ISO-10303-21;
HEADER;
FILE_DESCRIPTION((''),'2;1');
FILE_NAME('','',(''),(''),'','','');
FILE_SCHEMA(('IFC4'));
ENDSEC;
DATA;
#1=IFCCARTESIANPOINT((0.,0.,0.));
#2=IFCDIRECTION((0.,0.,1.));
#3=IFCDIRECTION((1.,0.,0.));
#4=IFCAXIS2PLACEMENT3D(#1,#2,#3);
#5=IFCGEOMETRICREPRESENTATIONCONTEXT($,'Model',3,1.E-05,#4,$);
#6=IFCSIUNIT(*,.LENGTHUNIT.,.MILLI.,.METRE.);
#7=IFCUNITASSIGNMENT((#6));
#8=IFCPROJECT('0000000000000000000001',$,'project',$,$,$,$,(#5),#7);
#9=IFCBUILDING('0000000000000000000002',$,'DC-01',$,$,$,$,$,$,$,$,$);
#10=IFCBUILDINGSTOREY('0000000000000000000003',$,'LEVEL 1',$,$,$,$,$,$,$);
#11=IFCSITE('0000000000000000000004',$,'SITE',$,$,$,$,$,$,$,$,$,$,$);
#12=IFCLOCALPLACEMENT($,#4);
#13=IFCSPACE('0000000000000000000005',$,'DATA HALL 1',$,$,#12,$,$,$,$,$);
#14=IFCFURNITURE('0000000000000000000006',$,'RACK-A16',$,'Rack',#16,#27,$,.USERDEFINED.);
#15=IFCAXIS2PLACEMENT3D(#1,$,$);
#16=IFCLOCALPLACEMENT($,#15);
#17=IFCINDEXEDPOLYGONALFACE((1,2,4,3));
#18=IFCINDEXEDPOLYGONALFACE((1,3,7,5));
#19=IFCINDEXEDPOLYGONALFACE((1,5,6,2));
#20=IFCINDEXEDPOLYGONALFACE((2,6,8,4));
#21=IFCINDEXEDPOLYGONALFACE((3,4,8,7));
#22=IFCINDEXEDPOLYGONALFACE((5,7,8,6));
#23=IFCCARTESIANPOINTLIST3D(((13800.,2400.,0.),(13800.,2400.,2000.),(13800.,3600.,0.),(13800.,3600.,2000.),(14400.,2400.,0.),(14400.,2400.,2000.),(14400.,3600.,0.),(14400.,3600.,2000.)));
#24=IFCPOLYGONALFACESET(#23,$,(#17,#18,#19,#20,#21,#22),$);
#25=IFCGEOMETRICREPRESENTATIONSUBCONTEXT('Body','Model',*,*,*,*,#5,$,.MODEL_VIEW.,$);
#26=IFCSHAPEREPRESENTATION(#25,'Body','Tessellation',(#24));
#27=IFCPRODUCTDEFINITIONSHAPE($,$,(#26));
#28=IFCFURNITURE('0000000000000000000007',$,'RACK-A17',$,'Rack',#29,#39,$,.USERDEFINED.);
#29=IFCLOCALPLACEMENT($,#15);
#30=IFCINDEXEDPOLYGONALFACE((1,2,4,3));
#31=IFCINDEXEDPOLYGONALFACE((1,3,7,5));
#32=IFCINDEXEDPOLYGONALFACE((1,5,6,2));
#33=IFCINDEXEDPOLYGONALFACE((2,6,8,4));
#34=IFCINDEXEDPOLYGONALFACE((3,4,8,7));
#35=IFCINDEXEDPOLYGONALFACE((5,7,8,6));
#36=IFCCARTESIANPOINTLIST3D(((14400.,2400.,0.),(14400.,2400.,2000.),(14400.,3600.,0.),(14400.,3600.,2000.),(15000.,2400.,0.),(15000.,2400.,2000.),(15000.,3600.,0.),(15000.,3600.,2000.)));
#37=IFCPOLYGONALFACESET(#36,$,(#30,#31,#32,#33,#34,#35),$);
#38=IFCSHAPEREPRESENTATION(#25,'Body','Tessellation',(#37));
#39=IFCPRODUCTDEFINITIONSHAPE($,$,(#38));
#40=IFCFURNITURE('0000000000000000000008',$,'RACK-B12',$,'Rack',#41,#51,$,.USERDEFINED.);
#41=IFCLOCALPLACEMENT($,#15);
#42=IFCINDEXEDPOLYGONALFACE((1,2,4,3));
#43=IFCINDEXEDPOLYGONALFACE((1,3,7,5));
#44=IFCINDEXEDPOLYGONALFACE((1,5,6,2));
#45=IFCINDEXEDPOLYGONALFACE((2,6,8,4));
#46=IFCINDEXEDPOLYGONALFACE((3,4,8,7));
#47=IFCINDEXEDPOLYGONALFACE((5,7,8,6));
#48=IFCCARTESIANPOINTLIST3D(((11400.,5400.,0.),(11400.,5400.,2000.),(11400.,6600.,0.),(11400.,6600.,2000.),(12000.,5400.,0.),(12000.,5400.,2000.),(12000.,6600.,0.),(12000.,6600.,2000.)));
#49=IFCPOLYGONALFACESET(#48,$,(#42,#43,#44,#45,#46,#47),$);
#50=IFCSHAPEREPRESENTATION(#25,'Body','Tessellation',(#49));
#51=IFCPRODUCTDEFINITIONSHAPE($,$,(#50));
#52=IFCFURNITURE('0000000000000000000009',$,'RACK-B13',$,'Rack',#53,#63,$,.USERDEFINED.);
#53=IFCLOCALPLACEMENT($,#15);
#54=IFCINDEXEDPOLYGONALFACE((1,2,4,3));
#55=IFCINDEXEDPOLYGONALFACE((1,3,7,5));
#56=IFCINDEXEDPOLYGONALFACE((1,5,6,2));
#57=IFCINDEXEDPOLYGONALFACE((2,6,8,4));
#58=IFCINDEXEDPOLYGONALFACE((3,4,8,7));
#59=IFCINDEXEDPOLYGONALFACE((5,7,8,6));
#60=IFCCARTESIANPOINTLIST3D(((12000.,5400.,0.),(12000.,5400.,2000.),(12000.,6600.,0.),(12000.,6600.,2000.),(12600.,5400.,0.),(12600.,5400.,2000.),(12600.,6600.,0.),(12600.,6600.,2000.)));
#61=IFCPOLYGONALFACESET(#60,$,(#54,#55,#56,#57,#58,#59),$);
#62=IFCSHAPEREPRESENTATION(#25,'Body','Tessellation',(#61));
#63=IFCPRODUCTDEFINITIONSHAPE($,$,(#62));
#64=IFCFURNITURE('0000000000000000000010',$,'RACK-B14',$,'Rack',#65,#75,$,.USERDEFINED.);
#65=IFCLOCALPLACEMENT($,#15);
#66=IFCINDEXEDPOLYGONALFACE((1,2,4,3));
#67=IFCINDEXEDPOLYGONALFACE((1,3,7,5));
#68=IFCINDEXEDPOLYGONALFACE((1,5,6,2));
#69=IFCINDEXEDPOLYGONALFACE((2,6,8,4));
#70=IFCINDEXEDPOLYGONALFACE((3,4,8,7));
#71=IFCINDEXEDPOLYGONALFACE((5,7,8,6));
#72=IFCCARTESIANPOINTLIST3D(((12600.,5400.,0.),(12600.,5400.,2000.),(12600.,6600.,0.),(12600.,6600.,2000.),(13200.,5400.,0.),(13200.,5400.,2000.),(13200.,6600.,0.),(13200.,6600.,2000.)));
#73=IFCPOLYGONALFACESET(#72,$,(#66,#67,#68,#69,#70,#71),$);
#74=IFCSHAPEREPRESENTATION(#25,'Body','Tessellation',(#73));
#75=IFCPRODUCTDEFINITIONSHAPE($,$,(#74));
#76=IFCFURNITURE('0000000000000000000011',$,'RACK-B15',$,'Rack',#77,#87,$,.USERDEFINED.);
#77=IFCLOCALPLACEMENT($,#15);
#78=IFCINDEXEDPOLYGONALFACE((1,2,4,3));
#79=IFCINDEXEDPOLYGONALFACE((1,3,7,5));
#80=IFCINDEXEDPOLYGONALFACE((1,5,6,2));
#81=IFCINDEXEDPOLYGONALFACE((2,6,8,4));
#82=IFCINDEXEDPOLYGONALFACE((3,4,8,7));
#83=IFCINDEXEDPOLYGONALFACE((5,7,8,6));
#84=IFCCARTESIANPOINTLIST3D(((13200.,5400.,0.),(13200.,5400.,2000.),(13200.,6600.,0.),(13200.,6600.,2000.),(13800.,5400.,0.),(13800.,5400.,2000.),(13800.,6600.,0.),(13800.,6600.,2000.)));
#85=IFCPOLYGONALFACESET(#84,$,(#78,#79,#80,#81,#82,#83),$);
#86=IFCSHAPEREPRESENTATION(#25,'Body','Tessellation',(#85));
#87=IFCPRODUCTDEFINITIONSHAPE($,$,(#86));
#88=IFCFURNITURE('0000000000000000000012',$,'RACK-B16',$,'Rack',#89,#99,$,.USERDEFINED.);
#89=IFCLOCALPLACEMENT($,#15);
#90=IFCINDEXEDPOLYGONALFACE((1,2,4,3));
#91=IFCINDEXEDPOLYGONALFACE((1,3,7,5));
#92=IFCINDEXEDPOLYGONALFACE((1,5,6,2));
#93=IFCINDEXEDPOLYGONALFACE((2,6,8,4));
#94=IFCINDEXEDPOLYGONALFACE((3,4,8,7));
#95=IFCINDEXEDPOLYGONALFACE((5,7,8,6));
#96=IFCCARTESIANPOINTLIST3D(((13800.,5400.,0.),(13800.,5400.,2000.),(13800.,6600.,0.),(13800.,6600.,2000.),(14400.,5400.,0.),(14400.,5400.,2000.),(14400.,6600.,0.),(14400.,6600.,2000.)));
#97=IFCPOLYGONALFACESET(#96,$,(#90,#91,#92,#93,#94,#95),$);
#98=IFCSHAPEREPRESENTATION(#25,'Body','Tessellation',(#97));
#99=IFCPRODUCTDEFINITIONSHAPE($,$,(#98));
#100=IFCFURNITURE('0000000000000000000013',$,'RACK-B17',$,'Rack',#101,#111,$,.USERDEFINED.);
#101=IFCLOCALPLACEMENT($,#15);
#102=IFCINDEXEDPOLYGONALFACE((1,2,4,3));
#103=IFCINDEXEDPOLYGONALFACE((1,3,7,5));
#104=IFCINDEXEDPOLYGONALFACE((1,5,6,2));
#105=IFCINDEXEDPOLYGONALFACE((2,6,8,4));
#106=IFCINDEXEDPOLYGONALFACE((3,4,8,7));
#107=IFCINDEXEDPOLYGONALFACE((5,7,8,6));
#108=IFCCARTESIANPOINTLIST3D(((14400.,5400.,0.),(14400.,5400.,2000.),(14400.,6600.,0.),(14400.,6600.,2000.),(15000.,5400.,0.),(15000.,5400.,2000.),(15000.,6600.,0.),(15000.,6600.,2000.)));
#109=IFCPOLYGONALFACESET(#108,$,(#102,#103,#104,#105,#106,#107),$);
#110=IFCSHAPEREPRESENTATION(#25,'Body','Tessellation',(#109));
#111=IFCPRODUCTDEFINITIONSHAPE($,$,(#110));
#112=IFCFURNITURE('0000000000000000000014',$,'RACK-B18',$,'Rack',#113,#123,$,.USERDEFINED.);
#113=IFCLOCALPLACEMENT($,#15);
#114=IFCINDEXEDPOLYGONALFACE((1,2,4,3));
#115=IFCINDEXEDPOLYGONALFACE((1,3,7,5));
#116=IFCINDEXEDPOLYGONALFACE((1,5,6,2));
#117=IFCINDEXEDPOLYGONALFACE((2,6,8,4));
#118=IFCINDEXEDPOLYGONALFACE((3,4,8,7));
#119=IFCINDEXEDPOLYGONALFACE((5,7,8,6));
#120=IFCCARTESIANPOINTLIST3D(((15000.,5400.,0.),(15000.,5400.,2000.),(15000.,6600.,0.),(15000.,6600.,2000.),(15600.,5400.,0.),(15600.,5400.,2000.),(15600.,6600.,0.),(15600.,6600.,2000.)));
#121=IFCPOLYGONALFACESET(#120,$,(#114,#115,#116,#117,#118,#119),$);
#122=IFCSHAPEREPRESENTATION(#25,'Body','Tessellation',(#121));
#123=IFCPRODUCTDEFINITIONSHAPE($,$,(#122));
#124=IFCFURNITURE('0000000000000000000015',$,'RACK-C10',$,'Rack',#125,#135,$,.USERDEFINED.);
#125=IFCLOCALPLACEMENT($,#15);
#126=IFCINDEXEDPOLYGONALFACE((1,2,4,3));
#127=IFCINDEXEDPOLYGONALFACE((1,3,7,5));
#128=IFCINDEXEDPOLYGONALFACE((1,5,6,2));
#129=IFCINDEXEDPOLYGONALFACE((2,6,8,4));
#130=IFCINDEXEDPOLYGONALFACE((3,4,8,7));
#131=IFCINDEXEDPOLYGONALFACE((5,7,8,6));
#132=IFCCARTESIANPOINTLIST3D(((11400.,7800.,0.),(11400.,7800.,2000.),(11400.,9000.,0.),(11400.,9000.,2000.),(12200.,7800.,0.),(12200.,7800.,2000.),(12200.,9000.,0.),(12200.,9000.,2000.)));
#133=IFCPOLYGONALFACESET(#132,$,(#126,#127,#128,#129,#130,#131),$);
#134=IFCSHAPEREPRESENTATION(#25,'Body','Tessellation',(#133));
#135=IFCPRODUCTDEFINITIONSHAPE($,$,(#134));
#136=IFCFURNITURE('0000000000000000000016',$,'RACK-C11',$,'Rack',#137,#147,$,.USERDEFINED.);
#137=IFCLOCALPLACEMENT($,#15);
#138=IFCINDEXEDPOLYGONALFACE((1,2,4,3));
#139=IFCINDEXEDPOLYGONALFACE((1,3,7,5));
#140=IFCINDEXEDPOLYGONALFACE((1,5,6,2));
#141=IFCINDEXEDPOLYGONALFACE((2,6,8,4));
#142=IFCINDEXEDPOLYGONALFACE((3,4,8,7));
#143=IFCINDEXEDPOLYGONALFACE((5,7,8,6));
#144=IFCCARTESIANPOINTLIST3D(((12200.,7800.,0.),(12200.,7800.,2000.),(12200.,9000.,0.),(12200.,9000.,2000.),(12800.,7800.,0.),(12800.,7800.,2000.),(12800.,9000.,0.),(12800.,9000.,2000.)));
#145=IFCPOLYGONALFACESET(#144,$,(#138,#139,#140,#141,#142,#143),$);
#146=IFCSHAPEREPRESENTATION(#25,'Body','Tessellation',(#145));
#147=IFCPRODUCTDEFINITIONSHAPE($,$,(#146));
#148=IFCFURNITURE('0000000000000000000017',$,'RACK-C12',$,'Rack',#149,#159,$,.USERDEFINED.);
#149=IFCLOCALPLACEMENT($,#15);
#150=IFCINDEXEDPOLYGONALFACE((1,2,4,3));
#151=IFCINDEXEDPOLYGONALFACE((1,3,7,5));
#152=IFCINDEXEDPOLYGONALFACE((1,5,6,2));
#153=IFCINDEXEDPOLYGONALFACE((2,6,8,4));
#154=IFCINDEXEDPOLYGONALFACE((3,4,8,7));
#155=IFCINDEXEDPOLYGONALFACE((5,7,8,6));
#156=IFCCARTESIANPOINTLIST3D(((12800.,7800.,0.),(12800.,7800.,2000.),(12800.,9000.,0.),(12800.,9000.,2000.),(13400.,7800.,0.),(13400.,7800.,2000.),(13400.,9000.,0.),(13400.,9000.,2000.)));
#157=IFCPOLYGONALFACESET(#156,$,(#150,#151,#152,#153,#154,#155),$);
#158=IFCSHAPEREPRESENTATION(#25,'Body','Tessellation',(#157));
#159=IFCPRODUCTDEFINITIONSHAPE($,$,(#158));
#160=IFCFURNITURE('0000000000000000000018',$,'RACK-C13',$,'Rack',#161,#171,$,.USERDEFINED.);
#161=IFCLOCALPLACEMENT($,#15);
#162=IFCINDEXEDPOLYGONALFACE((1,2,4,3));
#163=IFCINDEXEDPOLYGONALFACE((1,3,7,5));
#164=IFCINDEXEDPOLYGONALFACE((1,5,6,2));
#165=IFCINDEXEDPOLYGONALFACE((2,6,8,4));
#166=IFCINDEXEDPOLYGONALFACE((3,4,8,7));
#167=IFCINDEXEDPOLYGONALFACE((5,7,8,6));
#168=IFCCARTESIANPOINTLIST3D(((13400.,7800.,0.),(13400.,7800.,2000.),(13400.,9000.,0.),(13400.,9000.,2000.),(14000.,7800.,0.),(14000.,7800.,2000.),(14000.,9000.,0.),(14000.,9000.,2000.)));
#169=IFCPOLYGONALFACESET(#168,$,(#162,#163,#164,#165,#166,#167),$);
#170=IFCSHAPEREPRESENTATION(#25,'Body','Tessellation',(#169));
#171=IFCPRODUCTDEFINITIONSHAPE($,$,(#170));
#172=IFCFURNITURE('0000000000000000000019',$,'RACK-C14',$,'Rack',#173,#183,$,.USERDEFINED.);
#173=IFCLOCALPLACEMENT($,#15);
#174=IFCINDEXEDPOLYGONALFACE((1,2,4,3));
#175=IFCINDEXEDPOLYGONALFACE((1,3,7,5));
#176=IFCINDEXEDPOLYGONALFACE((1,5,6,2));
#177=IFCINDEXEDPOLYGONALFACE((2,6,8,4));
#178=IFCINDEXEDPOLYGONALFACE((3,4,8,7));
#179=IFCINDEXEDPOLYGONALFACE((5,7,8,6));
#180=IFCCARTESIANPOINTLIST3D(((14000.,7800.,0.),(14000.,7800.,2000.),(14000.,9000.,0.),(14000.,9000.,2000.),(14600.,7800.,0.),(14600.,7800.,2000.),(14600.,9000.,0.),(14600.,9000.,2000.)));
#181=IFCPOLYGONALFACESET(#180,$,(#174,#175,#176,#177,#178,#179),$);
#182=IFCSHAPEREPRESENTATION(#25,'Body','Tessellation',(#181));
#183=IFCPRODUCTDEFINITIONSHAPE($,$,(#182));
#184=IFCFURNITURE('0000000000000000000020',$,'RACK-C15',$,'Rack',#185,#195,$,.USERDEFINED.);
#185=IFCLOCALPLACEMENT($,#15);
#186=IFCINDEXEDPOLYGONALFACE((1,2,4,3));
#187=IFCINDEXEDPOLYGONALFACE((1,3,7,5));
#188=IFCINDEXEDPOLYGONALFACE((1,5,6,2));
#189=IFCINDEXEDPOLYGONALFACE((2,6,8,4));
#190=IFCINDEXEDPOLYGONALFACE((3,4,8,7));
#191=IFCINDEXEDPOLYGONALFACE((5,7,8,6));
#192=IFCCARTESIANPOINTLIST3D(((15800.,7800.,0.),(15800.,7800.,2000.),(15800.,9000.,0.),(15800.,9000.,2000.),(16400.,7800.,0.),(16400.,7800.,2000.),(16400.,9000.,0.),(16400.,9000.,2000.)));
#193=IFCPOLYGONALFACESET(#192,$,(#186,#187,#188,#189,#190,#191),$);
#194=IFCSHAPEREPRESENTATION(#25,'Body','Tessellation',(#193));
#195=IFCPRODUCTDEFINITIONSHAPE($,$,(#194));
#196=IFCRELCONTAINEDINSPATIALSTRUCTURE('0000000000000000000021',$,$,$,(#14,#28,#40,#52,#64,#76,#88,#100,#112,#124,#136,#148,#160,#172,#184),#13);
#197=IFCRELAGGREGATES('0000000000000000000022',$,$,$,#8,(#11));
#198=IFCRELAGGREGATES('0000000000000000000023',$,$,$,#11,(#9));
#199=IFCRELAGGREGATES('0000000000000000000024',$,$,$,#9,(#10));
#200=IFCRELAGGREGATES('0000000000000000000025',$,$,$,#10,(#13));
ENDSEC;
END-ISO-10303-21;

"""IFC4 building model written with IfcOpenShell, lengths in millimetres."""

from ifc_helpers import new_model, si_unit, frame, origin, origin_with_axes, place, context, subcontext, project, spatial, polyline, outline, extrude, element, save


model = new_model("IFC4")

# Units and contexts
model_context = context("Model", 3, precision=1e-05, world=origin_with_axes())
body_context = subcontext(model_context, "Body", "Model", "MODEL_VIEW")
ifc_project = project(units=[si_unit("LENGTHUNIT", "METRE", prefix="MILLI")], contexts=[model_context])

# Site, building, storey, space
site = spatial("IfcSite", under=ifc_project, Name="SITE")
building = spatial("IfcBuilding", under=site, Name="DC-01")
storey = spatial("IfcBuildingStorey", under=building, Name="LEVEL 1")
space_placement = place(None, origin_with_axes())
space = spatial("IfcSpace", under=storey, at=space_placement, Name="DATA HALL 1")

# Furniture
for number, where, z_axis, x_axis, name in (
    (1, (14400.0, 3600.0, 0.0), (0.0, 0.0, 1.0), (-1.0, 0.0, 0.0), "RACK-A16"),
    (2, (15000.0, 3600.0, 0.0), (0.0, 0.0, 1.0), (-1.0, 0.0, 0.0), "RACK-A17"),
    (3, (11400.0, 5400.0, 0.0), (0.0, 0.0, 1.0), (1.0, 0.0, 0.0), "RACK-B12"),
    (4, (12000.0, 5400.0, 0.0), (0.0, 0.0, 1.0), (1.0, 0.0, 0.0), "RACK-B13"),
    (5, (12600.0, 5400.0, 0.0), (0.0, 0.0, 1.0), (1.0, 0.0, 0.0), "RACK-B14"),
    (6, (13200.0, 5400.0, 0.0), (0.0, 0.0, 1.0), (1.0, 0.0, 0.0), "RACK-B15"),
    (7, (13800.0, 5400.0, 0.0), (0.0, 0.0, 1.0), (1.0, 0.0, 0.0), "RACK-B16"),
    (8, (14400.0, 5400.0, 0.0), (0.0, 0.0, 1.0), (1.0, 0.0, 0.0), "RACK-B17"),
    (9, (15000.0, 5400.0, 0.0), (0.0, 0.0, 1.0), (1.0, 0.0, 0.0), "RACK-B18"),
):
    element("IfcFurniture", number, at=place(space_placement, frame(where, z_axis=z_axis, x_axis=x_axis)), inside=space, Name=name, ObjectType="Rack", PredefinedType="USERDEFINED", context=body_context, shape_type="SweptSolid", body=[
        extrude(outline(polyline([(0.0, 0.0), (600.0, 0.0), (600.0, 1200.0), (0.0, 1200.0), (0.0, 0.0)])), origin(), (0.0, 0.0, 1.0), 2000.0),
    ])
furniture_placement = place(space_placement, frame((12200.0, 9000.0, 0.0), z_axis=(0.0, 0.0, 1.0), x_axis=(-1.0, 0.0, 0.0)))
element("IfcFurniture", 10, at=furniture_placement, inside=space, Name="RACK-C10", ObjectType="Rack", PredefinedType="USERDEFINED", context=body_context, shape_type="SweptSolid", body=[
    extrude(outline(polyline([(0.0, 0.0), (800.0, 0.0), (800.0, 1200.0), (0.0, 1200.0), (0.0, 0.0)])), origin(), (0.0, 0.0, 1.0), 2000.0),
])
for number, where, z_axis, x_axis, name in (
    (11, (12800.0, 9000.0, 0.0), (0.0, 0.0, 1.0), (-1.0, 0.0, 0.0), "RACK-C11"),
    (12, (13400.0, 9000.0, 0.0), (0.0, 0.0, 1.0), (-1.0, 0.0, 0.0), "RACK-C12"),
    (13, (14000.0, 9000.0, 0.0), (0.0, 0.0, 1.0), (-1.0, 0.0, 0.0), "RACK-C13"),
    (14, (14600.0, 9000.0, 0.0), (0.0, 0.0, 1.0), (-1.0, 0.0, 0.0), "RACK-C14"),
    (15, (16400.0, 9000.0, 0.0), (0.0, 0.0, 1.0), (-1.0, 0.0, 0.0), "RACK-C15"),
):
    element("IfcFurniture", number, at=place(space_placement, frame(where, z_axis=z_axis, x_axis=x_axis)), inside=space, Name=name, ObjectType="Rack", PredefinedType="USERDEFINED", context=body_context, shape_type="SweptSolid", body=[
        extrude(outline(polyline([(0.0, 0.0), (600.0, 0.0), (600.0, 1200.0), (0.0, 1200.0), (0.0, 0.0)])), origin(), (0.0, 0.0, 1.0), 2000.0),
    ])

save(model, "model.ifc")
